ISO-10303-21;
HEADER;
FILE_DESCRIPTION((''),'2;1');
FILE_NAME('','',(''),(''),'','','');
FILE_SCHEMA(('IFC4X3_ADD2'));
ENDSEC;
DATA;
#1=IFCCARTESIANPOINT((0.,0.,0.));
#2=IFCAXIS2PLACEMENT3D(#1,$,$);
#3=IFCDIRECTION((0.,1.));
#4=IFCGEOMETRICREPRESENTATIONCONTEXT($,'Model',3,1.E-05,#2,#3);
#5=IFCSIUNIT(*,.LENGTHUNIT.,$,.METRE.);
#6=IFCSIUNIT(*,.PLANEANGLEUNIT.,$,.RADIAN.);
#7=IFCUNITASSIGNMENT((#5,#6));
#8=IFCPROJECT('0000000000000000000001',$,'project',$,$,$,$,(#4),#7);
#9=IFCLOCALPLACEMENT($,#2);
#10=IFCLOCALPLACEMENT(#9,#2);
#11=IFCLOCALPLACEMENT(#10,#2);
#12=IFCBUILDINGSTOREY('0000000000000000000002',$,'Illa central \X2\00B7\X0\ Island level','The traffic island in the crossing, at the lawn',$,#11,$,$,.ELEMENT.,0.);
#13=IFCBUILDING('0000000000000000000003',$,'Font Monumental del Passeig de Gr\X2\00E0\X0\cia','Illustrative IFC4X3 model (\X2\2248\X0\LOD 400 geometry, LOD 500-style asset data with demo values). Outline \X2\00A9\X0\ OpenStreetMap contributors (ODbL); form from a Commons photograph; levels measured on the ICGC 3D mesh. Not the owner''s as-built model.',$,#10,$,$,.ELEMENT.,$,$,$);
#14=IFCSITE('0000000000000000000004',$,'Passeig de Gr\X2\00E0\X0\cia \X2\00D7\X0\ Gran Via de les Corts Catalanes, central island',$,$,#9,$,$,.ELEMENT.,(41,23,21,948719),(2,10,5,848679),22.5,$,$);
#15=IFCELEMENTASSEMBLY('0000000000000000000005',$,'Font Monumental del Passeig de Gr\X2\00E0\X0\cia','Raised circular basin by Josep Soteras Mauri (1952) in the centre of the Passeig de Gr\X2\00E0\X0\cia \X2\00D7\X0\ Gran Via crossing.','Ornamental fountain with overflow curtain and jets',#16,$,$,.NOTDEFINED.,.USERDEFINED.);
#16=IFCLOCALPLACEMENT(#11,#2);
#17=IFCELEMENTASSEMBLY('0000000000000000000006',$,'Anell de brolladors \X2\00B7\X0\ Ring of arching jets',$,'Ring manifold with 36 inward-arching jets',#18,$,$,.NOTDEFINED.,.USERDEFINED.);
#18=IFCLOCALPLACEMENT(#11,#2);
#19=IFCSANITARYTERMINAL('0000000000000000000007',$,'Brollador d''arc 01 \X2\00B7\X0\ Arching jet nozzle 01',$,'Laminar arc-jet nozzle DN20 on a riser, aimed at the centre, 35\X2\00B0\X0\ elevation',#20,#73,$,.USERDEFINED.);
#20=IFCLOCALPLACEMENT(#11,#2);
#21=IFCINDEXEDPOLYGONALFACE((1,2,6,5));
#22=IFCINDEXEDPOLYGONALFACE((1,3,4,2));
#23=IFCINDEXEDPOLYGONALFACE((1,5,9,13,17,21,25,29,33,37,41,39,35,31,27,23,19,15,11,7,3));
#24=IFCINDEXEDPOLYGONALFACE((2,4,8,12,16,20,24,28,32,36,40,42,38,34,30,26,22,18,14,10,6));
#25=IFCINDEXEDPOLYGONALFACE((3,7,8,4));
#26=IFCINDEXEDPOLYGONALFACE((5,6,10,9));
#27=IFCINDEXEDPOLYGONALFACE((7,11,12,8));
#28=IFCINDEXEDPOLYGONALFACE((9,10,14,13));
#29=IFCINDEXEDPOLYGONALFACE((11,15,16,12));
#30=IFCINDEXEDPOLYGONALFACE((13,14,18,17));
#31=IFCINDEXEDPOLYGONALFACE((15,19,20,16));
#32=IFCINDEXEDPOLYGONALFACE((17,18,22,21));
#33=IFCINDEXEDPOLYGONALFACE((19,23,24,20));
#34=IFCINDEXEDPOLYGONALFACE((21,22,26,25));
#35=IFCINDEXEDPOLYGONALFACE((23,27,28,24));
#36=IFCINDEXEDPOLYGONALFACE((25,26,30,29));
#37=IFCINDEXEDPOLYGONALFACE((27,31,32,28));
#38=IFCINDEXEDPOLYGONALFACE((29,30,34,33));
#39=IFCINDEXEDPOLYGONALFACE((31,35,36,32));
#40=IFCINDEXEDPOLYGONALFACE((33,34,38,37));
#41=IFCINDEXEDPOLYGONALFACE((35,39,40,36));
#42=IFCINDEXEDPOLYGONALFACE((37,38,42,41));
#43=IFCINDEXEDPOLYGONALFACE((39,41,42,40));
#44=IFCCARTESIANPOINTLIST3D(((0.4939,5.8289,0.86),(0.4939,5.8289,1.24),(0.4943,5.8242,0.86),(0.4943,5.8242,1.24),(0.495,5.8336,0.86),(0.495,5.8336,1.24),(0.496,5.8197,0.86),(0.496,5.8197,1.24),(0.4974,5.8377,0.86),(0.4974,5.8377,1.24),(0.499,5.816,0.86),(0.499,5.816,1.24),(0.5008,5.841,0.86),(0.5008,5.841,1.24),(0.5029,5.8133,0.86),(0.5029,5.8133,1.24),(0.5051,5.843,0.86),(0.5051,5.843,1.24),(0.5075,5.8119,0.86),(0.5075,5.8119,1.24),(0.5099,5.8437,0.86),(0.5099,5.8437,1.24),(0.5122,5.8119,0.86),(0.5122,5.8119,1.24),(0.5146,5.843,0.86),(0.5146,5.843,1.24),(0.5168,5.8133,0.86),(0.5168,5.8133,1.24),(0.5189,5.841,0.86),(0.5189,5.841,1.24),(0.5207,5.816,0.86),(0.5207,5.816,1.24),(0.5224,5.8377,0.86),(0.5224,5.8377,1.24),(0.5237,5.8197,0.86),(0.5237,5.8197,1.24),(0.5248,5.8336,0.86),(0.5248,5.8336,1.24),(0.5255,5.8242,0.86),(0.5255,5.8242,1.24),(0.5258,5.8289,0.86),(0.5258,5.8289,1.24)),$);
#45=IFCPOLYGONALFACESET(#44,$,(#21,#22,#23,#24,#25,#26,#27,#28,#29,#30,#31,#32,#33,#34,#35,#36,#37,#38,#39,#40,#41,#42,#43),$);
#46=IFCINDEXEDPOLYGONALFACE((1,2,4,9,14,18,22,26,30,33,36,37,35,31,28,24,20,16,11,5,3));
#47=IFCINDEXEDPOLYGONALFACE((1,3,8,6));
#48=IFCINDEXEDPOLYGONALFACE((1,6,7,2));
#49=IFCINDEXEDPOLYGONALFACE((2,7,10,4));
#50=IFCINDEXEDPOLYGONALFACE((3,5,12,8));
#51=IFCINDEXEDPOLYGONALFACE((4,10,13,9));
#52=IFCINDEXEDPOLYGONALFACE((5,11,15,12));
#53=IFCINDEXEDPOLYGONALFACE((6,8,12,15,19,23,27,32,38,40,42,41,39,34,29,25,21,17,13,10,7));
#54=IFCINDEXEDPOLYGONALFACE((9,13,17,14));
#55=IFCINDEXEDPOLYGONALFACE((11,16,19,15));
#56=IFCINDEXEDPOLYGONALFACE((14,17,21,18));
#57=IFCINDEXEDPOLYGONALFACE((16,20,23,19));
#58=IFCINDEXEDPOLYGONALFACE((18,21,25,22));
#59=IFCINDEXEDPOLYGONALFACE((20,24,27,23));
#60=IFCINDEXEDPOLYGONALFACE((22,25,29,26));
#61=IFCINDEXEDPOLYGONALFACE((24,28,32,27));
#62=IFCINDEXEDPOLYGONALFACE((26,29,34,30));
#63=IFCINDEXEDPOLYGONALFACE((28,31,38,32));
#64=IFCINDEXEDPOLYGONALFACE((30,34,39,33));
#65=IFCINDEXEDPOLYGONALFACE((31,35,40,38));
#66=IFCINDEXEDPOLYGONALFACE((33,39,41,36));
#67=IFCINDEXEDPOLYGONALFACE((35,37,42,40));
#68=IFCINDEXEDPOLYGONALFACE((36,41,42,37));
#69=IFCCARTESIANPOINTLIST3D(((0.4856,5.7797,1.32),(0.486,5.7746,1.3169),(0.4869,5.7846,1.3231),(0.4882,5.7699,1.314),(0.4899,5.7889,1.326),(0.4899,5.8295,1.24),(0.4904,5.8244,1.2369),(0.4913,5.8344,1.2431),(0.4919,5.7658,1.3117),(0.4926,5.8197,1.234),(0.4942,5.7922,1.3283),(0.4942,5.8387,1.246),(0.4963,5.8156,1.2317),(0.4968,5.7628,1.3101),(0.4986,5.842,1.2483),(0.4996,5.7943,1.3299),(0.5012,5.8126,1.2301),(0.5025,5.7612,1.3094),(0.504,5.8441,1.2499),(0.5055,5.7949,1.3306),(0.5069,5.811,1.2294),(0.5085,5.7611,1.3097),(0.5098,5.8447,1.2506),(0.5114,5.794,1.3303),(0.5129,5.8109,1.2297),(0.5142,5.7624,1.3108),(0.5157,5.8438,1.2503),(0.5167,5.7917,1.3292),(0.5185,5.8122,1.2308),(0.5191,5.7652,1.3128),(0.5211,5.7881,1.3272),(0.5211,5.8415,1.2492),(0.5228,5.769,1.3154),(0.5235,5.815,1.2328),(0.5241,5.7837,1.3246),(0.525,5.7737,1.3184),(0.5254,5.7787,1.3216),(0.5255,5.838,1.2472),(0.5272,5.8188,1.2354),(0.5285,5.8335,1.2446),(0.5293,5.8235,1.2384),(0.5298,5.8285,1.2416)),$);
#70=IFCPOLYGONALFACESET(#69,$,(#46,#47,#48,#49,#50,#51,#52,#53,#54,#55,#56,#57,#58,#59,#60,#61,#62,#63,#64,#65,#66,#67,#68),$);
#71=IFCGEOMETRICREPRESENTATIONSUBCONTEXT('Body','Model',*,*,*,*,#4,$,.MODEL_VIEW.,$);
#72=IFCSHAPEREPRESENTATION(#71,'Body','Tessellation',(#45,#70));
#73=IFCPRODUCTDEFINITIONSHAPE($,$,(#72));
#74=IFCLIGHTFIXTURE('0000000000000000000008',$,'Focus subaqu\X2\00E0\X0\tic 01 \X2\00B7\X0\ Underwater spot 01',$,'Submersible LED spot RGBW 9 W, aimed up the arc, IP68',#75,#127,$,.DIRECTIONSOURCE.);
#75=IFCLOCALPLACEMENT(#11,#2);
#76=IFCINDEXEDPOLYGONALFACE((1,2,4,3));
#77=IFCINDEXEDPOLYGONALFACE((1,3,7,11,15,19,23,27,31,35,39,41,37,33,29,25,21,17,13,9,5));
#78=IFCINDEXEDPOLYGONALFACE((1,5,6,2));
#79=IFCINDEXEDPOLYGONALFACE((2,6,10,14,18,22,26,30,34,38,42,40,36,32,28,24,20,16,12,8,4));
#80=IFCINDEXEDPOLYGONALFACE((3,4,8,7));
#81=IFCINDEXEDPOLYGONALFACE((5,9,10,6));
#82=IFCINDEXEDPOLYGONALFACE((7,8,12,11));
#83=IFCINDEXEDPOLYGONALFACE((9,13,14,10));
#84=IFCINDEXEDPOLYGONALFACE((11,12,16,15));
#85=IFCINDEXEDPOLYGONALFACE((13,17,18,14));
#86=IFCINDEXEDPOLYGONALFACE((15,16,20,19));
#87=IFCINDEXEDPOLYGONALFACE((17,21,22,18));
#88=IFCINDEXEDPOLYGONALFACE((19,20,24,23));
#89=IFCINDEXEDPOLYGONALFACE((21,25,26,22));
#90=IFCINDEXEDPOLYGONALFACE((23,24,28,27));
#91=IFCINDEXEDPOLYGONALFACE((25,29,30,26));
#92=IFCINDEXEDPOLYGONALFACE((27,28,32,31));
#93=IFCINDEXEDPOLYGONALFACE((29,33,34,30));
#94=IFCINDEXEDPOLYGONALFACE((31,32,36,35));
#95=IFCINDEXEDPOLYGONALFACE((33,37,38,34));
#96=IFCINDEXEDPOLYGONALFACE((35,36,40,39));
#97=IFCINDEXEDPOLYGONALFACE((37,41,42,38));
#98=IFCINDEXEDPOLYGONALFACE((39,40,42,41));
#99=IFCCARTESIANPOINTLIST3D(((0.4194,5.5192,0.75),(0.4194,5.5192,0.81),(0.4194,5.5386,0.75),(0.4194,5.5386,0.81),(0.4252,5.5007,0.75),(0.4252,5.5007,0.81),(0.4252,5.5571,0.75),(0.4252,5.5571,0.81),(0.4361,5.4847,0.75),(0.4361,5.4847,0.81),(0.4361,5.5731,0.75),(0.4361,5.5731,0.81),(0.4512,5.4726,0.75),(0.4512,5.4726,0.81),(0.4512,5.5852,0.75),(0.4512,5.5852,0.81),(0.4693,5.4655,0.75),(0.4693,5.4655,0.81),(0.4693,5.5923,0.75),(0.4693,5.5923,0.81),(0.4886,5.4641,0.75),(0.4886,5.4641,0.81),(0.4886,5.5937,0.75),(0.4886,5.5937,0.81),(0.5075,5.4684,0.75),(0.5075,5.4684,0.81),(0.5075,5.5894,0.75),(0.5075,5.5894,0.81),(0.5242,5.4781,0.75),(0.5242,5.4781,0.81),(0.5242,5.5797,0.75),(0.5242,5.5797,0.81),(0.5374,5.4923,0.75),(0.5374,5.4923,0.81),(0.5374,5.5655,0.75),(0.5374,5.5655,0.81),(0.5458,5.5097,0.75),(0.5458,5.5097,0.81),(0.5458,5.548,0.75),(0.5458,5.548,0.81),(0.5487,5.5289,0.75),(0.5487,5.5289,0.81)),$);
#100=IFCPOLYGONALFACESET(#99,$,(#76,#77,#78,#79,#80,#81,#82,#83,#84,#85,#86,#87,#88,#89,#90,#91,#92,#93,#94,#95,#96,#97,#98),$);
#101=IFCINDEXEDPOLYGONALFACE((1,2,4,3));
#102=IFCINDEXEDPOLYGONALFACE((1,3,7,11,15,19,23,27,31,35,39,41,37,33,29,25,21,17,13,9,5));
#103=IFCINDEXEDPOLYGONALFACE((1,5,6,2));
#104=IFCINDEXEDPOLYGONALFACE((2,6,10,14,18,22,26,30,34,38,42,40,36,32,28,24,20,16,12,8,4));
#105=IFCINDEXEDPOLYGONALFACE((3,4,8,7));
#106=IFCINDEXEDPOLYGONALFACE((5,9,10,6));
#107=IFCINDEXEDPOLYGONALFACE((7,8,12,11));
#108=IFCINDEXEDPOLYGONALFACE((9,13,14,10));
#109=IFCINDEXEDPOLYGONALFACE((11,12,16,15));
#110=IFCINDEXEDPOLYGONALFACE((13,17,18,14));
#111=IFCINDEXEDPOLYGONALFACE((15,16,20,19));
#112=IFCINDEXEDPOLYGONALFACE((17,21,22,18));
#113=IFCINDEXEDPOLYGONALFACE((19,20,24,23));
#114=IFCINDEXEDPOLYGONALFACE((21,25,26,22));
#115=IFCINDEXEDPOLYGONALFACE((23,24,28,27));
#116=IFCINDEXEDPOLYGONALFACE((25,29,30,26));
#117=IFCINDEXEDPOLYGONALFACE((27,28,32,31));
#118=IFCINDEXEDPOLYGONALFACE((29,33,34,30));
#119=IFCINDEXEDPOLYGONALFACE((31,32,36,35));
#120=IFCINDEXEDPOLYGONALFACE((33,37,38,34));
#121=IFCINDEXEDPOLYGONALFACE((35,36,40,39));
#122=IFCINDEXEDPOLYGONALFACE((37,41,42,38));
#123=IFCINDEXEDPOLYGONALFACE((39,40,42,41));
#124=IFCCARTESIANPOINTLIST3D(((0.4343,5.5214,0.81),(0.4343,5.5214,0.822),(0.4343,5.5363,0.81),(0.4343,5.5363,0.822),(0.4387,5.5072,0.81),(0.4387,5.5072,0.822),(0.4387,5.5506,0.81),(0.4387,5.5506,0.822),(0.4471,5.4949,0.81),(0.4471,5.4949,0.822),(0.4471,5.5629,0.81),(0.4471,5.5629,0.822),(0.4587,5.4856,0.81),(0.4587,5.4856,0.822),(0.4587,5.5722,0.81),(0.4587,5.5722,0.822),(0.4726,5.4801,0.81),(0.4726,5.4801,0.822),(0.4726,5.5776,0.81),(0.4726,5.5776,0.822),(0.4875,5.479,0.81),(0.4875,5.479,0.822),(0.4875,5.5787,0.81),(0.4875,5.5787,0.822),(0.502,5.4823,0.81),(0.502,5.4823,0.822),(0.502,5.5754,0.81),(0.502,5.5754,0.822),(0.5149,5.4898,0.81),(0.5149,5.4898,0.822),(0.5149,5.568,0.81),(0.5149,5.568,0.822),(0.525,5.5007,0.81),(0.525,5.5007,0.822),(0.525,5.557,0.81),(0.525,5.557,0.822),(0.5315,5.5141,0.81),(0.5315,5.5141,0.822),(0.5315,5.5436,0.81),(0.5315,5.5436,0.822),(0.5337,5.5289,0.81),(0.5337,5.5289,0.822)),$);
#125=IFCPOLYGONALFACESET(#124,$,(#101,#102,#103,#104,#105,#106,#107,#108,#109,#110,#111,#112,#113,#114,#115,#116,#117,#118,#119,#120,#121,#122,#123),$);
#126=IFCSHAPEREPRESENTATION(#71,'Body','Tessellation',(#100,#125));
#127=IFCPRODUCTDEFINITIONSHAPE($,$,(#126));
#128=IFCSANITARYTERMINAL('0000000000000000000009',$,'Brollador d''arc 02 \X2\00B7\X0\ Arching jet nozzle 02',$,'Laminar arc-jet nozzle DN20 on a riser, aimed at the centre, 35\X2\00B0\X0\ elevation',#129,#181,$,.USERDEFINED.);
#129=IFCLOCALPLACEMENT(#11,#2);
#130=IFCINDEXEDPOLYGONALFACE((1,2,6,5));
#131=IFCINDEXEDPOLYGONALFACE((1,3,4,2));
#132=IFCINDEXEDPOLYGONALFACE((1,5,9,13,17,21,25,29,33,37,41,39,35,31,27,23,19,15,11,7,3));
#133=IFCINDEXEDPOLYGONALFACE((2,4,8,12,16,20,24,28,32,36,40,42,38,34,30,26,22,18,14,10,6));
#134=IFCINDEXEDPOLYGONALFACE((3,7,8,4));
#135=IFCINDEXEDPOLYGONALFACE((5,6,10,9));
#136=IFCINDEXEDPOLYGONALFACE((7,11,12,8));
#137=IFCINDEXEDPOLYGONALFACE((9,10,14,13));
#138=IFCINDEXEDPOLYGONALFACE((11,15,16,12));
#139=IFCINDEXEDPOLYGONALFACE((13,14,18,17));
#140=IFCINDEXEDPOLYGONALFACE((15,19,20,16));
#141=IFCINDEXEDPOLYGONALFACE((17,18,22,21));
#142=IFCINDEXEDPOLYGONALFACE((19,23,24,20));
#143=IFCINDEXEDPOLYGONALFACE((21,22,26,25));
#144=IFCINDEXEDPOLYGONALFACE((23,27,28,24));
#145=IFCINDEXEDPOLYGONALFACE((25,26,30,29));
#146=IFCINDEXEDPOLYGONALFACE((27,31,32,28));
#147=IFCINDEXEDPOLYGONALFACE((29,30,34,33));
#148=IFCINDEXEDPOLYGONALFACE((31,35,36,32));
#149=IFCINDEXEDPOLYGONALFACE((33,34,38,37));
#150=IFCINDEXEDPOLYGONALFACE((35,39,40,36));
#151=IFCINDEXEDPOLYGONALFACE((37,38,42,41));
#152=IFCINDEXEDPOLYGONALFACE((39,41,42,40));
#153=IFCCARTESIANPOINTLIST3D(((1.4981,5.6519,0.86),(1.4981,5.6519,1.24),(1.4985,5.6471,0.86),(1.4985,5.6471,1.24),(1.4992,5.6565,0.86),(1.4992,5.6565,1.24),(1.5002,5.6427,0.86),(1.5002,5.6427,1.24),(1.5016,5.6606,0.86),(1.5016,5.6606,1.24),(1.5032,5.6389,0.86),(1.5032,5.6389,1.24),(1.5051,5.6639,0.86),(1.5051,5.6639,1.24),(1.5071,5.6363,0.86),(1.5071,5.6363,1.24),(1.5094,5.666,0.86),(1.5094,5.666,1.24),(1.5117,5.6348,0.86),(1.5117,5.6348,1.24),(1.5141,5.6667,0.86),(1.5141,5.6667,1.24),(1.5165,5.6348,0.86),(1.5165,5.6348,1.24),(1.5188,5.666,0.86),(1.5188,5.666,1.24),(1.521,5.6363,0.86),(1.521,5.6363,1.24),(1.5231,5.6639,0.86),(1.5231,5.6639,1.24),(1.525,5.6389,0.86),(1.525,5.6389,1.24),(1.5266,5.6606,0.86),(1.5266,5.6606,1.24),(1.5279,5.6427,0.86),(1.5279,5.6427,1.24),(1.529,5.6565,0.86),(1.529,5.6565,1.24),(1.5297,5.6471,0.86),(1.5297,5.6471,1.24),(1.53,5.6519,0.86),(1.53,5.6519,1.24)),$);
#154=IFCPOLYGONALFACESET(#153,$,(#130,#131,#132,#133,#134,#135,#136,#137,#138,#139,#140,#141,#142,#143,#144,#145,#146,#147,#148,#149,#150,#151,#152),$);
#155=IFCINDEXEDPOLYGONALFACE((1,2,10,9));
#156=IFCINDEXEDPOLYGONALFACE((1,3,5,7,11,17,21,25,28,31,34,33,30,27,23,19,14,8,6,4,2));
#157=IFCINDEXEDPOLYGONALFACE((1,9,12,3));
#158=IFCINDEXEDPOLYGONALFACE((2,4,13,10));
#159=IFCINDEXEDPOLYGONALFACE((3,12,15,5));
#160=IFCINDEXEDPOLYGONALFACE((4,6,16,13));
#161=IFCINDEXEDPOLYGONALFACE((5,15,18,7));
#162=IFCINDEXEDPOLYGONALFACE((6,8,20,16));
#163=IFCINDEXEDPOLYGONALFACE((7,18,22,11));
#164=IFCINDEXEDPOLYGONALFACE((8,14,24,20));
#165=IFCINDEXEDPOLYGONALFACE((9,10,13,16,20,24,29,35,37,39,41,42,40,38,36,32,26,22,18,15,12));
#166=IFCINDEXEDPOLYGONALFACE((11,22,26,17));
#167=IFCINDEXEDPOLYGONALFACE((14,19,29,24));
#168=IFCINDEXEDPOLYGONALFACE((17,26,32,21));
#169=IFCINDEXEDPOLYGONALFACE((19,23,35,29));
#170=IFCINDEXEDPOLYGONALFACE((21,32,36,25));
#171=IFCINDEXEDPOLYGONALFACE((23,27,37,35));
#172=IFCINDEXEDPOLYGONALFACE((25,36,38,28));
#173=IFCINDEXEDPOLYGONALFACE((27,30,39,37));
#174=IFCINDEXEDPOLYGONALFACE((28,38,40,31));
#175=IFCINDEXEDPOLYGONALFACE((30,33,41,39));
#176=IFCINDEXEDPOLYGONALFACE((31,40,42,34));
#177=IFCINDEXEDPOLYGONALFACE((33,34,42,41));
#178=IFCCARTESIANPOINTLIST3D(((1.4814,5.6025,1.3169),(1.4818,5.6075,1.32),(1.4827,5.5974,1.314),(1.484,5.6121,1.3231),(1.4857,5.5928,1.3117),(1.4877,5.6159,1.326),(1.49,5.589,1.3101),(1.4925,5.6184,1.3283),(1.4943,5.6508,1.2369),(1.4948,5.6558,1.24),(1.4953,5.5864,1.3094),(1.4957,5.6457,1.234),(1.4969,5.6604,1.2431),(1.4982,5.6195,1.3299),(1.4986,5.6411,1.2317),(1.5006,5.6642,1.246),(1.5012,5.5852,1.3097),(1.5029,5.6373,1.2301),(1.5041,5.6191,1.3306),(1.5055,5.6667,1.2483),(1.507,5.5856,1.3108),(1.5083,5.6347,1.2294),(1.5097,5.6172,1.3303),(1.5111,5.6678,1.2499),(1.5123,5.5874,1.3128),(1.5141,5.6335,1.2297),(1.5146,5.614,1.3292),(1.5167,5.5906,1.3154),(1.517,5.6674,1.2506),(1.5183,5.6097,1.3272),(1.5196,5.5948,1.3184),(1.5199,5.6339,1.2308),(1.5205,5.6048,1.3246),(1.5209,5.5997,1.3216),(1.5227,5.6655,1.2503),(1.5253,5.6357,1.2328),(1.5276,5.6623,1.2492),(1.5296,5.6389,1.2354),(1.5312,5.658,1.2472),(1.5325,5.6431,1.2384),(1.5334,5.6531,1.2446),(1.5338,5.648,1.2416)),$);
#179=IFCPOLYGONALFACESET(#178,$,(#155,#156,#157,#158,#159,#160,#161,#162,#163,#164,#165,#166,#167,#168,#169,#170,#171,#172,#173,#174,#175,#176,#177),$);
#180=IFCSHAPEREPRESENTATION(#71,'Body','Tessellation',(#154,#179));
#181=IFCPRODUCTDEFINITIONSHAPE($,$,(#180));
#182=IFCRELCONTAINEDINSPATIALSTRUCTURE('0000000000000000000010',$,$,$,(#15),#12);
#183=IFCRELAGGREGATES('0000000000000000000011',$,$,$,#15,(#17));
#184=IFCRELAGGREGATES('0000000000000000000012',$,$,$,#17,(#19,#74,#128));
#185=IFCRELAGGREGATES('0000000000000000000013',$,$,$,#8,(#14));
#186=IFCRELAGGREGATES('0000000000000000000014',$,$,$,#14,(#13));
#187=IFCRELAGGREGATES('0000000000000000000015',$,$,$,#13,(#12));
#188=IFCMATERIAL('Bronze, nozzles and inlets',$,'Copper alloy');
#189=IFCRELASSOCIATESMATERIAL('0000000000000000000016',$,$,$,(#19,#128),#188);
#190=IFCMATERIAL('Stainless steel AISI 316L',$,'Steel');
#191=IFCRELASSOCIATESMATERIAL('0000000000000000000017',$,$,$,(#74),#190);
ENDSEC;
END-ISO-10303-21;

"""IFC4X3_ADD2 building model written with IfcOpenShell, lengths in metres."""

from ifc_helpers import new_model, si_unit, direction, frame, origin, origin_2d_with_axis, place, context, subcontext, project, spatial, circle, extrude, material, element, aggregate, save


model = new_model("IFC4X3_ADD2")

# Units and contexts
model_context = context("Model", 3, precision=1e-05, world=origin(), true_north=direction((0.0, 1.0)))
body_context = subcontext(model_context, "Body", "Model", "MODEL_VIEW")
ifc_project = project(units=[si_unit("LENGTHUNIT", "METRE"), si_unit("PLANEANGLEUNIT", "RADIAN")], contexts=[model_context])

# Site, building, storey
site_placement = place(None, origin())
site = spatial("IfcSite", under=ifc_project, at=site_placement, Name="Passeig de Gràcia × Gran Via de les Corts Catalanes, central island", CompositionType="ELEMENT", RefLatitude=(41, 23, 21, 948719), RefLongitude=(2, 10, 5, 848679), RefElevation=22.5)
building_placement = place(site_placement, origin())
building = spatial("IfcBuilding", under=site, at=building_placement, Name="Font Monumental del Passeig de Gràcia", Description="Illustrative IFC4X3 model (≈LOD 400 geometry, LOD 500-style asset data with demo values). Outline © OpenStreetMap contributors (ODbL); form from a Commons photograph; levels measured on the ICGC 3D mesh. Not the owner's as-built model.", CompositionType="ELEMENT")
storey_placement = place(building_placement, origin())
storey = spatial("IfcBuildingStorey", under=building, at=storey_placement, Name="Illa central · Island level", Description="The traffic island in the crossing, at the lawn", CompositionType="ELEMENT", Elevation=0.0)

# Element assemblies, sanitary terminals, light fixture
assembly_1_placement = place(building_placement, origin())
assembly_1 = element("IfcElementAssembly", 1, at=assembly_1_placement, inside=storey, Name="Font Monumental del Passeig de Gràcia", Description="Raised circular basin by Josep Soteras Mauri (1952) in the centre of the Passeig de Gràcia × Gran Via crossing.", ObjectType="Ornamental fountain with overflow curtain and jets", AssemblyPlace="NOTDEFINED", PredefinedType="USERDEFINED")
ifc_material_1 = material(Name="Bronze, nozzles and inlets", Category="Copper alloy")
ifc_material_2 = material(Name="Stainless steel AISI 316L", Category="Steel")
assembly_2_placement = place(building_placement, origin())
assembly_2 = element("IfcElementAssembly", 2, at=assembly_2_placement, Name="Anell de brolladors · Ring of arching jets", ObjectType="Ring manifold with 36 inward-arching jets", AssemblyPlace="NOTDEFINED", PredefinedType="USERDEFINED")
sanitary_terminal_1_placement = place(building_placement, origin())
sanitary_terminal_1 = element("IfcSanitaryTerminal", 3, at=sanitary_terminal_1_placement, material=ifc_material_1, Name="Brollador d'arc 01 · Arching jet nozzle 01", ObjectType="Laminar arc-jet nozzle DN20 on a riser, aimed at the centre, 35° elevation", PredefinedType="USERDEFINED", context=body_context, shape_type="SweptSolid", body=[
    extrude(circle(Radius=0.016, at=origin_2d_with_axis()), frame((0.5099, 5.8277, 0.86), z_axis=(0.0, 0.0, 1.0), x_axis=(0.0, 1.0, 0.0)), (0.0, 0.0, 1.0), 0.38),
    extrude(circle(Radius=0.02, at=origin_2d_with_axis()), frame((0.5099, 5.8277, 1.24), z_axis=(-0.046192, -0.527982, 0.847998), x_axis=(-0.996195, 0.087156, 0.0)), (0.0, 0.0, 1.0), 0.0943),
])
light_fixture_1_placement = place(building_placement, origin())
light_fixture_1 = element("IfcLightFixture", 4, at=light_fixture_1_placement, material=ifc_material_2, Name="Focus subaquàtic 01 · Underwater spot 01", ObjectType="Submersible LED spot RGBW 9 W, aimed up the arc, IP68", PredefinedType="DIRECTIONSOURCE", context=body_context, shape_type="SweptSolid", body=[
    extrude(circle(Radius=0.065, at=origin_2d_with_axis()), frame((0.4837, 5.5289, 0.75)), (0.0, 0.0, 1.0), 0.06),
    extrude(circle(Radius=0.05, at=origin_2d_with_axis()), frame((0.4837, 5.5289, 0.81)), (0.0, 0.0, 1.0), 0.012),
])
sanitary_terminal_2_placement = place(building_placement, origin())
sanitary_terminal_2 = element("IfcSanitaryTerminal", 5, at=sanitary_terminal_2_placement, material=ifc_material_1, Name="Brollador d'arc 02 · Arching jet nozzle 02", ObjectType="Laminar arc-jet nozzle DN20 on a riser, aimed at the centre, 35° elevation", PredefinedType="USERDEFINED", context=body_context, shape_type="SweptSolid", body=[
    extrude(circle(Radius=0.016, at=origin_2d_with_axis()), frame((1.5141, 5.6507, 0.86), z_axis=(0.0, 0.0, 1.0), x_axis=(0.0, 1.0, 0.0)), (0.0, 0.0, 1.0), 0.38),
    extrude(circle(Radius=0.02, at=origin_2d_with_axis()), frame((1.5141, 5.6507, 1.24), z_axis=(-0.137174, -0.51194, 0.847998), x_axis=(-0.965926, 0.258819, 0.0)), (0.0, 0.0, 1.0), 0.0943),
])
aggregate(assembly_1, [assembly_2])
aggregate(assembly_2, [sanitary_terminal_1, light_fixture_1, sanitary_terminal_2])

save(model, "model.ifc")
